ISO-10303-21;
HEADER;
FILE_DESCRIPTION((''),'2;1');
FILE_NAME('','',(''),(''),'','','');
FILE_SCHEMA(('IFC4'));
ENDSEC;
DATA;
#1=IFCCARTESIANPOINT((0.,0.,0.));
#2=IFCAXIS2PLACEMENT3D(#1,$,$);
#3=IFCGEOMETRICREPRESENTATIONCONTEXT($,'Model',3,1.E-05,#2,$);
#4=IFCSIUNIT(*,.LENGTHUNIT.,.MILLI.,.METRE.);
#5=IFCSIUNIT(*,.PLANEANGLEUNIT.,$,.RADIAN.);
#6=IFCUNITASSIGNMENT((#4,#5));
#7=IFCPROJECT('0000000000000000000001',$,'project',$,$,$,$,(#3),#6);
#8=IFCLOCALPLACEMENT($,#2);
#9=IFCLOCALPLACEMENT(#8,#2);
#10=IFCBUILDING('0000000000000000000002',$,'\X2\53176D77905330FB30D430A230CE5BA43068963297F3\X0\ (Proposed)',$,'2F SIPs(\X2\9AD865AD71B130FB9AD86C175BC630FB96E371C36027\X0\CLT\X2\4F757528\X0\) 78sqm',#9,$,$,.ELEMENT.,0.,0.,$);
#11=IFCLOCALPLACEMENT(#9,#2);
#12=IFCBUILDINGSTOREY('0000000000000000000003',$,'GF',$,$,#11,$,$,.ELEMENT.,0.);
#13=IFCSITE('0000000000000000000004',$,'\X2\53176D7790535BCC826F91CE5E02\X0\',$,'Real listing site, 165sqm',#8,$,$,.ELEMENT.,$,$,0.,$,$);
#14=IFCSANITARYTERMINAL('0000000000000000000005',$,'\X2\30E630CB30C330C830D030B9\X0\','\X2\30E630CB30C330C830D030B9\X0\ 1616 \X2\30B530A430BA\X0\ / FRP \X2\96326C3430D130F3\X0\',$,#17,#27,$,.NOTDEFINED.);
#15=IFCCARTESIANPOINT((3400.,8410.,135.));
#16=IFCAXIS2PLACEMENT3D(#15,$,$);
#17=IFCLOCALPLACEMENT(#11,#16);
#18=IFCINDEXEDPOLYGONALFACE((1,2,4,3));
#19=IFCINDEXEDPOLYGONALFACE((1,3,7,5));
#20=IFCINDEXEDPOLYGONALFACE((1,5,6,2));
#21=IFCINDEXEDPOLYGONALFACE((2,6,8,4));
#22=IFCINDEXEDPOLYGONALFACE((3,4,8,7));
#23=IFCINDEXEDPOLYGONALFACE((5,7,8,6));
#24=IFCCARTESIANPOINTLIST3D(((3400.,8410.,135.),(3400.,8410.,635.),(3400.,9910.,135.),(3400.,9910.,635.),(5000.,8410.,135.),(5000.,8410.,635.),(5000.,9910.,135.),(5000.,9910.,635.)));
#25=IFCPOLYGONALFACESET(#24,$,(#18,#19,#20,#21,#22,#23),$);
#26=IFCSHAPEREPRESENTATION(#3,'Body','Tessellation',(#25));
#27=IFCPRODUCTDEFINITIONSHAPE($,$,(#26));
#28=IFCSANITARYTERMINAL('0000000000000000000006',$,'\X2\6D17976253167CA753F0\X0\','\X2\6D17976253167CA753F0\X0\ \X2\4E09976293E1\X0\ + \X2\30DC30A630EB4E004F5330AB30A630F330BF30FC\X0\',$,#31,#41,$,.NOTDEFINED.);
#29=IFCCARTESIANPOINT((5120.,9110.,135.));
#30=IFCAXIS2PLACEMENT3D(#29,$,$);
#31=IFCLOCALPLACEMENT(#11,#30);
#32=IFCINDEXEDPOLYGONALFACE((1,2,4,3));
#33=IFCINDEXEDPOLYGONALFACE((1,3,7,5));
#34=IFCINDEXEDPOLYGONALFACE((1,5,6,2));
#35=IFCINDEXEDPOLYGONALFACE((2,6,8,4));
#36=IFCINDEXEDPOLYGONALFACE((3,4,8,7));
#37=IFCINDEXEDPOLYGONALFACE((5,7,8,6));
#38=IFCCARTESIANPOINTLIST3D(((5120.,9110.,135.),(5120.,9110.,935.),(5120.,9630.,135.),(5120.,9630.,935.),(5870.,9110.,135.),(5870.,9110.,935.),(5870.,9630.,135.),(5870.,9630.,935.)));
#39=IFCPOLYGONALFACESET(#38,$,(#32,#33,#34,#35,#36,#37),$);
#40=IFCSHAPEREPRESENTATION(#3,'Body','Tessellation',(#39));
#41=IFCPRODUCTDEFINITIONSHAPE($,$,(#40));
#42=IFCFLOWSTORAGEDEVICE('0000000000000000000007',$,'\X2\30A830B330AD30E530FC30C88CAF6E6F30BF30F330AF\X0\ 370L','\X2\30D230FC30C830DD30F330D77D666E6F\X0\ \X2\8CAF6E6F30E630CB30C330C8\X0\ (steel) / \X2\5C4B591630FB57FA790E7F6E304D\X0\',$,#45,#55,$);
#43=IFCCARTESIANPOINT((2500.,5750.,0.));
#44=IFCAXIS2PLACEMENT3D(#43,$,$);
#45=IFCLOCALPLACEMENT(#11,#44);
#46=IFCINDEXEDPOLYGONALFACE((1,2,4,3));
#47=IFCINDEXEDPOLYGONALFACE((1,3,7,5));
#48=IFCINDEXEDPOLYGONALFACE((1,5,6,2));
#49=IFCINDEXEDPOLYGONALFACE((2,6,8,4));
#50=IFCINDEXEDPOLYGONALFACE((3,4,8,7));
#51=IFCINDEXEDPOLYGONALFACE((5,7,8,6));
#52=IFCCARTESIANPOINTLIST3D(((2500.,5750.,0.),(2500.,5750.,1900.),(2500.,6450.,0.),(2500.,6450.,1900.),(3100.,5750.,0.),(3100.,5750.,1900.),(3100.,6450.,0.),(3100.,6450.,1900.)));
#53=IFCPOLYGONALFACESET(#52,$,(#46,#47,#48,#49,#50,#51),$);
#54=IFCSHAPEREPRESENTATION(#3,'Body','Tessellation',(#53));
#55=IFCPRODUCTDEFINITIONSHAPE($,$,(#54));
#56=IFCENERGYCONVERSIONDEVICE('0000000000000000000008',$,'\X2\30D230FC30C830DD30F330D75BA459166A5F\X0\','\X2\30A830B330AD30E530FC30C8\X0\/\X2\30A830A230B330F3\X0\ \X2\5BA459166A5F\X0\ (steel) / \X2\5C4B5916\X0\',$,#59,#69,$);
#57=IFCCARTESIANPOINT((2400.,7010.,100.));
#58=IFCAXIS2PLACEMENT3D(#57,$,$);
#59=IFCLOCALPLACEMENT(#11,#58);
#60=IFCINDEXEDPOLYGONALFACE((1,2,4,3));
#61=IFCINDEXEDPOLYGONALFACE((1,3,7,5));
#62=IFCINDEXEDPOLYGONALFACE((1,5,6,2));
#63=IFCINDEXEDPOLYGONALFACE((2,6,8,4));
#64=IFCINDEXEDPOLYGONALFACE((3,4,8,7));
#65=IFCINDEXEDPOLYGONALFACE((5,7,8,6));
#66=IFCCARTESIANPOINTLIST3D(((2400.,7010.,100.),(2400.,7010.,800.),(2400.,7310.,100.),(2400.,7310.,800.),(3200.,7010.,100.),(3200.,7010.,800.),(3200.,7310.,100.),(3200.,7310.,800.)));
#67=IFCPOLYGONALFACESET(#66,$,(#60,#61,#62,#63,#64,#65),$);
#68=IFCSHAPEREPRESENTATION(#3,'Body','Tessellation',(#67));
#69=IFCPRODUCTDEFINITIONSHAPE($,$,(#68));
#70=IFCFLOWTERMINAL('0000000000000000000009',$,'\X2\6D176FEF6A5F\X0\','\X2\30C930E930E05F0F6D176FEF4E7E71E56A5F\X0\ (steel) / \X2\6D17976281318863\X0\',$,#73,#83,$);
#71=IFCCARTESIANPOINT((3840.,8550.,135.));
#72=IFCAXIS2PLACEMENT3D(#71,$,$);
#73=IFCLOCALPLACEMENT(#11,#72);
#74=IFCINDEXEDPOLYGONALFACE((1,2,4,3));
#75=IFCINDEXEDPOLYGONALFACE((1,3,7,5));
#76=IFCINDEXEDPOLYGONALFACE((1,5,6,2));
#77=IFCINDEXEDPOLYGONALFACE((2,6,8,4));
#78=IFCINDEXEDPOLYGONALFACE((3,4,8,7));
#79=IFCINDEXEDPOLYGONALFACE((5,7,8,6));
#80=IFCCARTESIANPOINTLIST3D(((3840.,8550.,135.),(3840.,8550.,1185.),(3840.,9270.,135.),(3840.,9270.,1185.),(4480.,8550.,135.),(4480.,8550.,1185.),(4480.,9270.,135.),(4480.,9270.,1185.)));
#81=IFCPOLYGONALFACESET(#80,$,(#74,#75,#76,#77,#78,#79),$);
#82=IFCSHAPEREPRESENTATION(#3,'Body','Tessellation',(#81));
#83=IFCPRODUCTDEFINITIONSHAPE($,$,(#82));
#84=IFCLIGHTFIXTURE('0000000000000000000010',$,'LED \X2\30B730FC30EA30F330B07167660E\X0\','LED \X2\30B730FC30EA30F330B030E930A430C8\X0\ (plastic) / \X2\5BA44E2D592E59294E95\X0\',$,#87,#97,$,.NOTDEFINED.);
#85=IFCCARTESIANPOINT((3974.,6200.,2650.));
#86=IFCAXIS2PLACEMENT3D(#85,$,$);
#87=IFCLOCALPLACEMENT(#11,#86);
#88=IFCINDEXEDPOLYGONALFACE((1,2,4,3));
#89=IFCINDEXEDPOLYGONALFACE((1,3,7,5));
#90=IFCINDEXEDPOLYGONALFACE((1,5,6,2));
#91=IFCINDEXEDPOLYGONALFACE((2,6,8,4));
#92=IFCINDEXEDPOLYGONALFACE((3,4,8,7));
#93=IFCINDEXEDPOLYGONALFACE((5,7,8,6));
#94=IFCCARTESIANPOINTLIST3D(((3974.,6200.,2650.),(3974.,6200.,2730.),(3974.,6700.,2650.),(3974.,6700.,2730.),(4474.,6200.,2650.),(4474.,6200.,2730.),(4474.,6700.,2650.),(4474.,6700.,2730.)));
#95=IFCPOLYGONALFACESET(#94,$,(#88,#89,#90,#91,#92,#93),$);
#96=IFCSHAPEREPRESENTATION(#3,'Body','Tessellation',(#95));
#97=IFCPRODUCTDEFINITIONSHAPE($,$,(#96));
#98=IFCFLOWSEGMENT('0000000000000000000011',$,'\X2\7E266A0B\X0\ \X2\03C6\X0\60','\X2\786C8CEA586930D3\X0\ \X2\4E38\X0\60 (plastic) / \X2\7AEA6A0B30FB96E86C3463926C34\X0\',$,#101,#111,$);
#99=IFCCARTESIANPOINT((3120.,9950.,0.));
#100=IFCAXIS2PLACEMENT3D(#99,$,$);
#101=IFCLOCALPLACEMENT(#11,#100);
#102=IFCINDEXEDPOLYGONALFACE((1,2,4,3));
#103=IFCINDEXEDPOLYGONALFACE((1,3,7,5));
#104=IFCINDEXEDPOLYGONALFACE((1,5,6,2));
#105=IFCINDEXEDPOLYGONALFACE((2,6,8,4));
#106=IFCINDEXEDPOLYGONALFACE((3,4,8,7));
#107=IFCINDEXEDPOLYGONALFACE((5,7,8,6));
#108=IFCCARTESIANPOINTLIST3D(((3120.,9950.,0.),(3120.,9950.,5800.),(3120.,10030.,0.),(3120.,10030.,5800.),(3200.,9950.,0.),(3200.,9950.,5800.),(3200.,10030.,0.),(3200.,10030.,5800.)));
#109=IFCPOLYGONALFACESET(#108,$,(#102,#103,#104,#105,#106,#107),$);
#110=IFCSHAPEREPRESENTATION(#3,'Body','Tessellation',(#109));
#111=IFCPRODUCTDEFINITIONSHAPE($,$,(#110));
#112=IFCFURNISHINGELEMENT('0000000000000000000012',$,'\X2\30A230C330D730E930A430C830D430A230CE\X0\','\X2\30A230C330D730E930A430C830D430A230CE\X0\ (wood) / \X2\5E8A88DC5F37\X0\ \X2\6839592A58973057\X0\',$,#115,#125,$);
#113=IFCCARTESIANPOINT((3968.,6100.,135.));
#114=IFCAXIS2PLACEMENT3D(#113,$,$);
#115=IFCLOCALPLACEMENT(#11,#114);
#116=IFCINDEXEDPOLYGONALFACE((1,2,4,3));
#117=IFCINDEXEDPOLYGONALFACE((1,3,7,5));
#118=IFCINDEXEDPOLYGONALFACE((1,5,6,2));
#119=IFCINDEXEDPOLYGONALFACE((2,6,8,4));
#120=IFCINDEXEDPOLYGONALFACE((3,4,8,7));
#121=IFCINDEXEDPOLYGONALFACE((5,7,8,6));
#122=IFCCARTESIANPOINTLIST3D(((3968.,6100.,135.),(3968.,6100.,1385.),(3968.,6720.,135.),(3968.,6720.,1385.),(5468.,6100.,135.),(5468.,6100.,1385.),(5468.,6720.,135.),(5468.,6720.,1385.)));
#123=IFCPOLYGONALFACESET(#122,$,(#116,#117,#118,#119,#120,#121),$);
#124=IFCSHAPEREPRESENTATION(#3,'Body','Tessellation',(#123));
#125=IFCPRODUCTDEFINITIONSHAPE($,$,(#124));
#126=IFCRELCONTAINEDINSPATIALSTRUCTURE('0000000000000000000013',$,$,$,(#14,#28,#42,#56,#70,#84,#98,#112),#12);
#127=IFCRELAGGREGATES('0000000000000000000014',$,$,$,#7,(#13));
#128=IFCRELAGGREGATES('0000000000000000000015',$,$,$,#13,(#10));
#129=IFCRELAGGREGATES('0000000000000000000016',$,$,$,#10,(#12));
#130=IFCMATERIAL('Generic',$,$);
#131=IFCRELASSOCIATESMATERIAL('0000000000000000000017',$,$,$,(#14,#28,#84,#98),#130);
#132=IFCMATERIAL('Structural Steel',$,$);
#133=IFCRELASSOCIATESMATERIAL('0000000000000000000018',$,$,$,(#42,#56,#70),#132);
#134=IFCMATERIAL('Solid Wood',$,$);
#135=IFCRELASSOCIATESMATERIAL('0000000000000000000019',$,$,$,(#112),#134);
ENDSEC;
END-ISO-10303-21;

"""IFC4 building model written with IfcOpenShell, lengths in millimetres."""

from ifc_helpers import new_model, si_unit, frame, frame_2d, origin, place, context, project, spatial, rectangle, extrude, material, element, save


model = new_model("IFC4")

# Units and contexts
model_context = context("Model", 3, precision=1e-05, world=origin())
ifc_project = project(units=[si_unit("LENGTHUNIT", "METRE", prefix="MILLI"), si_unit("PLANEANGLEUNIT", "RADIAN")], contexts=[model_context])

# Site, building, storey
site_placement = place(None, origin())
site = spatial("IfcSite", under=ifc_project, at=site_placement, Name="北海道富良野市", ObjectType="Real listing site, 165sqm", CompositionType="ELEMENT", RefElevation=0.0)
building_placement = place(site_placement, origin())
building = spatial("IfcBuilding", under=site, at=building_placement, Name="北海道・ピアノ室と防音 (Proposed)", ObjectType="2F SIPs(高断熱・高気密・難燃性CLT併用) 78sqm", CompositionType="ELEMENT", ElevationOfRefHeight=0.0, ElevationOfTerrain=0.0)
storey_placement = place(building_placement, origin())
storey = spatial("IfcBuildingStorey", under=building, at=storey_placement, Name="GF", CompositionType="ELEMENT", Elevation=0.0)

# Shared definitions
ifc_material_1 = material(Name="Solid Wood")

# Shared definitions
ifc_material_2 = material(Name="Generic")

# Sanitary terminals
sanitary_terminal_1_placement = place(storey_placement, frame((3400.0, 8410.0, 135.0)))
element("IfcSanitaryTerminal", 1, at=sanitary_terminal_1_placement, inside=storey, material=ifc_material_2, Name="ユニットバス", Description="ユニットバス 1616 サイズ / FRP 防水パン", PredefinedType="NOTDEFINED", context=model_context, shape_type="SweptSolid", body=[
    extrude(rectangle(XDim=1600.0, YDim=1500.0, at=frame_2d((800.0, 750.0))), frame((3400.0, 8410.0, 135.0)), (0.0, 0.0, 1.0), 500.0),
])
sanitary_terminal_2_placement = place(storey_placement, frame((5120.0, 9110.0, 135.0)))
element("IfcSanitaryTerminal", 2, at=sanitary_terminal_2_placement, inside=storey, material=ifc_material_2, Name="洗面化粧台", Description="洗面化粧台 三面鏡 + ボウル一体カウンター", PredefinedType="NOTDEFINED", context=model_context, shape_type="SweptSolid", body=[
    extrude(rectangle(XDim=750.0, YDim=520.0, at=frame_2d((375.0, 260.0))), frame((5120.0, 9110.0, 135.0)), (0.0, 0.0, 1.0), 800.0),
])

# Flow storage device
ifc_material_3 = material(Name="Structural Steel")
flow_storage_device_placement = place(storey_placement, frame((2500.0, 5750.0, 0.0)))
element("IfcFlowStorageDevice", 3, at=flow_storage_device_placement, inside=storey, material=ifc_material_3, Name="エコキュート貯湯タンク 370L", Description="ヒートポンプ給湯 貯湯ユニット (steel) / 屋外・基礎置き", context=model_context, shape_type="SweptSolid", body=[
    extrude(rectangle(XDim=600.0, YDim=700.0, at=frame_2d((300.0, 350.0))), frame((2500.0, 5750.0, 0.0)), (0.0, 0.0, 1.0), 1900.0),
])

# Energy conversion device
energy_conversion_device_placement = place(storey_placement, frame((2400.0, 7010.0, 100.0)))
element("IfcEnergyConversionDevice", 4, at=energy_conversion_device_placement, inside=storey, material=ifc_material_3, Name="ヒートポンプ室外機", Description="エコキュート/エアコン 室外機 (steel) / 屋外", context=model_context, shape_type="SweptSolid", body=[
    extrude(rectangle(XDim=800.0, YDim=300.0, at=frame_2d((400.0, 150.0))), frame((2400.0, 7010.0, 100.0)), (0.0, 0.0, 1.0), 700.0),
])

# Flow terminal
flow_terminal_placement = place(storey_placement, frame((3840.0, 8550.0, 135.0)))
element("IfcFlowTerminal", 5, at=flow_terminal_placement, inside=storey, material=ifc_material_3, Name="洗濯機", Description="ドラム式洗濯乾燥機 (steel) / 洗面脱衣", context=model_context, shape_type="SweptSolid", body=[
    extrude(rectangle(XDim=640.0, YDim=720.0, at=frame_2d((320.0, 360.0))), frame((3840.0, 8550.0, 135.0)), (0.0, 0.0, 1.0), 1050.0),
])

# Light fixture
light_fixture_placement = place(storey_placement, frame((3974.0, 6200.0, 2650.0)))
element("IfcLightFixture", 6, at=light_fixture_placement, inside=storey, material=ifc_material_2, Name="LED シーリング照明", Description="LED シーリングライト (plastic) / 室中央天井", PredefinedType="NOTDEFINED", context=model_context, shape_type="SweptSolid", body=[
    extrude(rectangle(XDim=500.0, YDim=500.0, at=frame_2d((250.0, 250.0))), frame((3974.0, 6200.0, 2650.0)), (0.0, 0.0, 1.0), 80.0),
])

# Flow segment
flow_segment_placement = place(storey_placement, frame((3120.0, 9950.0, 0.0)))
element("IfcFlowSegment", 7, at=flow_segment_placement, inside=storey, material=ifc_material_2, Name="縦樋 φ60", Description="硬質塩ビ 丸60 (plastic) / 竪樋・雨水排水", context=model_context, shape_type="SweptSolid", body=[
    extrude(rectangle(XDim=80.0, YDim=80.0, at=frame_2d((40.0, 40.0))), frame((3120.0, 9950.0, 0.0)), (0.0, 0.0, 1.0), 5800.0),
])

# Furnishing element
furnishing_placement = place(storey_placement, frame((3968.0, 6100.0, 135.0)))
element("IfcFurnishingElement", 8, at=furnishing_placement, inside=storey, material=ifc_material_1, Name="アップライトピアノ", Description="アップライトピアノ (wood) / 床補強 根太増し", context=model_context, shape_type="SweptSolid", body=[
    extrude(rectangle(XDim=1500.0, YDim=620.0, at=frame_2d((750.0, 310.0))), frame((3968.0, 6100.0, 135.0)), (0.0, 0.0, 1.0), 1250.0),
])

save(model, "model.ifc")
